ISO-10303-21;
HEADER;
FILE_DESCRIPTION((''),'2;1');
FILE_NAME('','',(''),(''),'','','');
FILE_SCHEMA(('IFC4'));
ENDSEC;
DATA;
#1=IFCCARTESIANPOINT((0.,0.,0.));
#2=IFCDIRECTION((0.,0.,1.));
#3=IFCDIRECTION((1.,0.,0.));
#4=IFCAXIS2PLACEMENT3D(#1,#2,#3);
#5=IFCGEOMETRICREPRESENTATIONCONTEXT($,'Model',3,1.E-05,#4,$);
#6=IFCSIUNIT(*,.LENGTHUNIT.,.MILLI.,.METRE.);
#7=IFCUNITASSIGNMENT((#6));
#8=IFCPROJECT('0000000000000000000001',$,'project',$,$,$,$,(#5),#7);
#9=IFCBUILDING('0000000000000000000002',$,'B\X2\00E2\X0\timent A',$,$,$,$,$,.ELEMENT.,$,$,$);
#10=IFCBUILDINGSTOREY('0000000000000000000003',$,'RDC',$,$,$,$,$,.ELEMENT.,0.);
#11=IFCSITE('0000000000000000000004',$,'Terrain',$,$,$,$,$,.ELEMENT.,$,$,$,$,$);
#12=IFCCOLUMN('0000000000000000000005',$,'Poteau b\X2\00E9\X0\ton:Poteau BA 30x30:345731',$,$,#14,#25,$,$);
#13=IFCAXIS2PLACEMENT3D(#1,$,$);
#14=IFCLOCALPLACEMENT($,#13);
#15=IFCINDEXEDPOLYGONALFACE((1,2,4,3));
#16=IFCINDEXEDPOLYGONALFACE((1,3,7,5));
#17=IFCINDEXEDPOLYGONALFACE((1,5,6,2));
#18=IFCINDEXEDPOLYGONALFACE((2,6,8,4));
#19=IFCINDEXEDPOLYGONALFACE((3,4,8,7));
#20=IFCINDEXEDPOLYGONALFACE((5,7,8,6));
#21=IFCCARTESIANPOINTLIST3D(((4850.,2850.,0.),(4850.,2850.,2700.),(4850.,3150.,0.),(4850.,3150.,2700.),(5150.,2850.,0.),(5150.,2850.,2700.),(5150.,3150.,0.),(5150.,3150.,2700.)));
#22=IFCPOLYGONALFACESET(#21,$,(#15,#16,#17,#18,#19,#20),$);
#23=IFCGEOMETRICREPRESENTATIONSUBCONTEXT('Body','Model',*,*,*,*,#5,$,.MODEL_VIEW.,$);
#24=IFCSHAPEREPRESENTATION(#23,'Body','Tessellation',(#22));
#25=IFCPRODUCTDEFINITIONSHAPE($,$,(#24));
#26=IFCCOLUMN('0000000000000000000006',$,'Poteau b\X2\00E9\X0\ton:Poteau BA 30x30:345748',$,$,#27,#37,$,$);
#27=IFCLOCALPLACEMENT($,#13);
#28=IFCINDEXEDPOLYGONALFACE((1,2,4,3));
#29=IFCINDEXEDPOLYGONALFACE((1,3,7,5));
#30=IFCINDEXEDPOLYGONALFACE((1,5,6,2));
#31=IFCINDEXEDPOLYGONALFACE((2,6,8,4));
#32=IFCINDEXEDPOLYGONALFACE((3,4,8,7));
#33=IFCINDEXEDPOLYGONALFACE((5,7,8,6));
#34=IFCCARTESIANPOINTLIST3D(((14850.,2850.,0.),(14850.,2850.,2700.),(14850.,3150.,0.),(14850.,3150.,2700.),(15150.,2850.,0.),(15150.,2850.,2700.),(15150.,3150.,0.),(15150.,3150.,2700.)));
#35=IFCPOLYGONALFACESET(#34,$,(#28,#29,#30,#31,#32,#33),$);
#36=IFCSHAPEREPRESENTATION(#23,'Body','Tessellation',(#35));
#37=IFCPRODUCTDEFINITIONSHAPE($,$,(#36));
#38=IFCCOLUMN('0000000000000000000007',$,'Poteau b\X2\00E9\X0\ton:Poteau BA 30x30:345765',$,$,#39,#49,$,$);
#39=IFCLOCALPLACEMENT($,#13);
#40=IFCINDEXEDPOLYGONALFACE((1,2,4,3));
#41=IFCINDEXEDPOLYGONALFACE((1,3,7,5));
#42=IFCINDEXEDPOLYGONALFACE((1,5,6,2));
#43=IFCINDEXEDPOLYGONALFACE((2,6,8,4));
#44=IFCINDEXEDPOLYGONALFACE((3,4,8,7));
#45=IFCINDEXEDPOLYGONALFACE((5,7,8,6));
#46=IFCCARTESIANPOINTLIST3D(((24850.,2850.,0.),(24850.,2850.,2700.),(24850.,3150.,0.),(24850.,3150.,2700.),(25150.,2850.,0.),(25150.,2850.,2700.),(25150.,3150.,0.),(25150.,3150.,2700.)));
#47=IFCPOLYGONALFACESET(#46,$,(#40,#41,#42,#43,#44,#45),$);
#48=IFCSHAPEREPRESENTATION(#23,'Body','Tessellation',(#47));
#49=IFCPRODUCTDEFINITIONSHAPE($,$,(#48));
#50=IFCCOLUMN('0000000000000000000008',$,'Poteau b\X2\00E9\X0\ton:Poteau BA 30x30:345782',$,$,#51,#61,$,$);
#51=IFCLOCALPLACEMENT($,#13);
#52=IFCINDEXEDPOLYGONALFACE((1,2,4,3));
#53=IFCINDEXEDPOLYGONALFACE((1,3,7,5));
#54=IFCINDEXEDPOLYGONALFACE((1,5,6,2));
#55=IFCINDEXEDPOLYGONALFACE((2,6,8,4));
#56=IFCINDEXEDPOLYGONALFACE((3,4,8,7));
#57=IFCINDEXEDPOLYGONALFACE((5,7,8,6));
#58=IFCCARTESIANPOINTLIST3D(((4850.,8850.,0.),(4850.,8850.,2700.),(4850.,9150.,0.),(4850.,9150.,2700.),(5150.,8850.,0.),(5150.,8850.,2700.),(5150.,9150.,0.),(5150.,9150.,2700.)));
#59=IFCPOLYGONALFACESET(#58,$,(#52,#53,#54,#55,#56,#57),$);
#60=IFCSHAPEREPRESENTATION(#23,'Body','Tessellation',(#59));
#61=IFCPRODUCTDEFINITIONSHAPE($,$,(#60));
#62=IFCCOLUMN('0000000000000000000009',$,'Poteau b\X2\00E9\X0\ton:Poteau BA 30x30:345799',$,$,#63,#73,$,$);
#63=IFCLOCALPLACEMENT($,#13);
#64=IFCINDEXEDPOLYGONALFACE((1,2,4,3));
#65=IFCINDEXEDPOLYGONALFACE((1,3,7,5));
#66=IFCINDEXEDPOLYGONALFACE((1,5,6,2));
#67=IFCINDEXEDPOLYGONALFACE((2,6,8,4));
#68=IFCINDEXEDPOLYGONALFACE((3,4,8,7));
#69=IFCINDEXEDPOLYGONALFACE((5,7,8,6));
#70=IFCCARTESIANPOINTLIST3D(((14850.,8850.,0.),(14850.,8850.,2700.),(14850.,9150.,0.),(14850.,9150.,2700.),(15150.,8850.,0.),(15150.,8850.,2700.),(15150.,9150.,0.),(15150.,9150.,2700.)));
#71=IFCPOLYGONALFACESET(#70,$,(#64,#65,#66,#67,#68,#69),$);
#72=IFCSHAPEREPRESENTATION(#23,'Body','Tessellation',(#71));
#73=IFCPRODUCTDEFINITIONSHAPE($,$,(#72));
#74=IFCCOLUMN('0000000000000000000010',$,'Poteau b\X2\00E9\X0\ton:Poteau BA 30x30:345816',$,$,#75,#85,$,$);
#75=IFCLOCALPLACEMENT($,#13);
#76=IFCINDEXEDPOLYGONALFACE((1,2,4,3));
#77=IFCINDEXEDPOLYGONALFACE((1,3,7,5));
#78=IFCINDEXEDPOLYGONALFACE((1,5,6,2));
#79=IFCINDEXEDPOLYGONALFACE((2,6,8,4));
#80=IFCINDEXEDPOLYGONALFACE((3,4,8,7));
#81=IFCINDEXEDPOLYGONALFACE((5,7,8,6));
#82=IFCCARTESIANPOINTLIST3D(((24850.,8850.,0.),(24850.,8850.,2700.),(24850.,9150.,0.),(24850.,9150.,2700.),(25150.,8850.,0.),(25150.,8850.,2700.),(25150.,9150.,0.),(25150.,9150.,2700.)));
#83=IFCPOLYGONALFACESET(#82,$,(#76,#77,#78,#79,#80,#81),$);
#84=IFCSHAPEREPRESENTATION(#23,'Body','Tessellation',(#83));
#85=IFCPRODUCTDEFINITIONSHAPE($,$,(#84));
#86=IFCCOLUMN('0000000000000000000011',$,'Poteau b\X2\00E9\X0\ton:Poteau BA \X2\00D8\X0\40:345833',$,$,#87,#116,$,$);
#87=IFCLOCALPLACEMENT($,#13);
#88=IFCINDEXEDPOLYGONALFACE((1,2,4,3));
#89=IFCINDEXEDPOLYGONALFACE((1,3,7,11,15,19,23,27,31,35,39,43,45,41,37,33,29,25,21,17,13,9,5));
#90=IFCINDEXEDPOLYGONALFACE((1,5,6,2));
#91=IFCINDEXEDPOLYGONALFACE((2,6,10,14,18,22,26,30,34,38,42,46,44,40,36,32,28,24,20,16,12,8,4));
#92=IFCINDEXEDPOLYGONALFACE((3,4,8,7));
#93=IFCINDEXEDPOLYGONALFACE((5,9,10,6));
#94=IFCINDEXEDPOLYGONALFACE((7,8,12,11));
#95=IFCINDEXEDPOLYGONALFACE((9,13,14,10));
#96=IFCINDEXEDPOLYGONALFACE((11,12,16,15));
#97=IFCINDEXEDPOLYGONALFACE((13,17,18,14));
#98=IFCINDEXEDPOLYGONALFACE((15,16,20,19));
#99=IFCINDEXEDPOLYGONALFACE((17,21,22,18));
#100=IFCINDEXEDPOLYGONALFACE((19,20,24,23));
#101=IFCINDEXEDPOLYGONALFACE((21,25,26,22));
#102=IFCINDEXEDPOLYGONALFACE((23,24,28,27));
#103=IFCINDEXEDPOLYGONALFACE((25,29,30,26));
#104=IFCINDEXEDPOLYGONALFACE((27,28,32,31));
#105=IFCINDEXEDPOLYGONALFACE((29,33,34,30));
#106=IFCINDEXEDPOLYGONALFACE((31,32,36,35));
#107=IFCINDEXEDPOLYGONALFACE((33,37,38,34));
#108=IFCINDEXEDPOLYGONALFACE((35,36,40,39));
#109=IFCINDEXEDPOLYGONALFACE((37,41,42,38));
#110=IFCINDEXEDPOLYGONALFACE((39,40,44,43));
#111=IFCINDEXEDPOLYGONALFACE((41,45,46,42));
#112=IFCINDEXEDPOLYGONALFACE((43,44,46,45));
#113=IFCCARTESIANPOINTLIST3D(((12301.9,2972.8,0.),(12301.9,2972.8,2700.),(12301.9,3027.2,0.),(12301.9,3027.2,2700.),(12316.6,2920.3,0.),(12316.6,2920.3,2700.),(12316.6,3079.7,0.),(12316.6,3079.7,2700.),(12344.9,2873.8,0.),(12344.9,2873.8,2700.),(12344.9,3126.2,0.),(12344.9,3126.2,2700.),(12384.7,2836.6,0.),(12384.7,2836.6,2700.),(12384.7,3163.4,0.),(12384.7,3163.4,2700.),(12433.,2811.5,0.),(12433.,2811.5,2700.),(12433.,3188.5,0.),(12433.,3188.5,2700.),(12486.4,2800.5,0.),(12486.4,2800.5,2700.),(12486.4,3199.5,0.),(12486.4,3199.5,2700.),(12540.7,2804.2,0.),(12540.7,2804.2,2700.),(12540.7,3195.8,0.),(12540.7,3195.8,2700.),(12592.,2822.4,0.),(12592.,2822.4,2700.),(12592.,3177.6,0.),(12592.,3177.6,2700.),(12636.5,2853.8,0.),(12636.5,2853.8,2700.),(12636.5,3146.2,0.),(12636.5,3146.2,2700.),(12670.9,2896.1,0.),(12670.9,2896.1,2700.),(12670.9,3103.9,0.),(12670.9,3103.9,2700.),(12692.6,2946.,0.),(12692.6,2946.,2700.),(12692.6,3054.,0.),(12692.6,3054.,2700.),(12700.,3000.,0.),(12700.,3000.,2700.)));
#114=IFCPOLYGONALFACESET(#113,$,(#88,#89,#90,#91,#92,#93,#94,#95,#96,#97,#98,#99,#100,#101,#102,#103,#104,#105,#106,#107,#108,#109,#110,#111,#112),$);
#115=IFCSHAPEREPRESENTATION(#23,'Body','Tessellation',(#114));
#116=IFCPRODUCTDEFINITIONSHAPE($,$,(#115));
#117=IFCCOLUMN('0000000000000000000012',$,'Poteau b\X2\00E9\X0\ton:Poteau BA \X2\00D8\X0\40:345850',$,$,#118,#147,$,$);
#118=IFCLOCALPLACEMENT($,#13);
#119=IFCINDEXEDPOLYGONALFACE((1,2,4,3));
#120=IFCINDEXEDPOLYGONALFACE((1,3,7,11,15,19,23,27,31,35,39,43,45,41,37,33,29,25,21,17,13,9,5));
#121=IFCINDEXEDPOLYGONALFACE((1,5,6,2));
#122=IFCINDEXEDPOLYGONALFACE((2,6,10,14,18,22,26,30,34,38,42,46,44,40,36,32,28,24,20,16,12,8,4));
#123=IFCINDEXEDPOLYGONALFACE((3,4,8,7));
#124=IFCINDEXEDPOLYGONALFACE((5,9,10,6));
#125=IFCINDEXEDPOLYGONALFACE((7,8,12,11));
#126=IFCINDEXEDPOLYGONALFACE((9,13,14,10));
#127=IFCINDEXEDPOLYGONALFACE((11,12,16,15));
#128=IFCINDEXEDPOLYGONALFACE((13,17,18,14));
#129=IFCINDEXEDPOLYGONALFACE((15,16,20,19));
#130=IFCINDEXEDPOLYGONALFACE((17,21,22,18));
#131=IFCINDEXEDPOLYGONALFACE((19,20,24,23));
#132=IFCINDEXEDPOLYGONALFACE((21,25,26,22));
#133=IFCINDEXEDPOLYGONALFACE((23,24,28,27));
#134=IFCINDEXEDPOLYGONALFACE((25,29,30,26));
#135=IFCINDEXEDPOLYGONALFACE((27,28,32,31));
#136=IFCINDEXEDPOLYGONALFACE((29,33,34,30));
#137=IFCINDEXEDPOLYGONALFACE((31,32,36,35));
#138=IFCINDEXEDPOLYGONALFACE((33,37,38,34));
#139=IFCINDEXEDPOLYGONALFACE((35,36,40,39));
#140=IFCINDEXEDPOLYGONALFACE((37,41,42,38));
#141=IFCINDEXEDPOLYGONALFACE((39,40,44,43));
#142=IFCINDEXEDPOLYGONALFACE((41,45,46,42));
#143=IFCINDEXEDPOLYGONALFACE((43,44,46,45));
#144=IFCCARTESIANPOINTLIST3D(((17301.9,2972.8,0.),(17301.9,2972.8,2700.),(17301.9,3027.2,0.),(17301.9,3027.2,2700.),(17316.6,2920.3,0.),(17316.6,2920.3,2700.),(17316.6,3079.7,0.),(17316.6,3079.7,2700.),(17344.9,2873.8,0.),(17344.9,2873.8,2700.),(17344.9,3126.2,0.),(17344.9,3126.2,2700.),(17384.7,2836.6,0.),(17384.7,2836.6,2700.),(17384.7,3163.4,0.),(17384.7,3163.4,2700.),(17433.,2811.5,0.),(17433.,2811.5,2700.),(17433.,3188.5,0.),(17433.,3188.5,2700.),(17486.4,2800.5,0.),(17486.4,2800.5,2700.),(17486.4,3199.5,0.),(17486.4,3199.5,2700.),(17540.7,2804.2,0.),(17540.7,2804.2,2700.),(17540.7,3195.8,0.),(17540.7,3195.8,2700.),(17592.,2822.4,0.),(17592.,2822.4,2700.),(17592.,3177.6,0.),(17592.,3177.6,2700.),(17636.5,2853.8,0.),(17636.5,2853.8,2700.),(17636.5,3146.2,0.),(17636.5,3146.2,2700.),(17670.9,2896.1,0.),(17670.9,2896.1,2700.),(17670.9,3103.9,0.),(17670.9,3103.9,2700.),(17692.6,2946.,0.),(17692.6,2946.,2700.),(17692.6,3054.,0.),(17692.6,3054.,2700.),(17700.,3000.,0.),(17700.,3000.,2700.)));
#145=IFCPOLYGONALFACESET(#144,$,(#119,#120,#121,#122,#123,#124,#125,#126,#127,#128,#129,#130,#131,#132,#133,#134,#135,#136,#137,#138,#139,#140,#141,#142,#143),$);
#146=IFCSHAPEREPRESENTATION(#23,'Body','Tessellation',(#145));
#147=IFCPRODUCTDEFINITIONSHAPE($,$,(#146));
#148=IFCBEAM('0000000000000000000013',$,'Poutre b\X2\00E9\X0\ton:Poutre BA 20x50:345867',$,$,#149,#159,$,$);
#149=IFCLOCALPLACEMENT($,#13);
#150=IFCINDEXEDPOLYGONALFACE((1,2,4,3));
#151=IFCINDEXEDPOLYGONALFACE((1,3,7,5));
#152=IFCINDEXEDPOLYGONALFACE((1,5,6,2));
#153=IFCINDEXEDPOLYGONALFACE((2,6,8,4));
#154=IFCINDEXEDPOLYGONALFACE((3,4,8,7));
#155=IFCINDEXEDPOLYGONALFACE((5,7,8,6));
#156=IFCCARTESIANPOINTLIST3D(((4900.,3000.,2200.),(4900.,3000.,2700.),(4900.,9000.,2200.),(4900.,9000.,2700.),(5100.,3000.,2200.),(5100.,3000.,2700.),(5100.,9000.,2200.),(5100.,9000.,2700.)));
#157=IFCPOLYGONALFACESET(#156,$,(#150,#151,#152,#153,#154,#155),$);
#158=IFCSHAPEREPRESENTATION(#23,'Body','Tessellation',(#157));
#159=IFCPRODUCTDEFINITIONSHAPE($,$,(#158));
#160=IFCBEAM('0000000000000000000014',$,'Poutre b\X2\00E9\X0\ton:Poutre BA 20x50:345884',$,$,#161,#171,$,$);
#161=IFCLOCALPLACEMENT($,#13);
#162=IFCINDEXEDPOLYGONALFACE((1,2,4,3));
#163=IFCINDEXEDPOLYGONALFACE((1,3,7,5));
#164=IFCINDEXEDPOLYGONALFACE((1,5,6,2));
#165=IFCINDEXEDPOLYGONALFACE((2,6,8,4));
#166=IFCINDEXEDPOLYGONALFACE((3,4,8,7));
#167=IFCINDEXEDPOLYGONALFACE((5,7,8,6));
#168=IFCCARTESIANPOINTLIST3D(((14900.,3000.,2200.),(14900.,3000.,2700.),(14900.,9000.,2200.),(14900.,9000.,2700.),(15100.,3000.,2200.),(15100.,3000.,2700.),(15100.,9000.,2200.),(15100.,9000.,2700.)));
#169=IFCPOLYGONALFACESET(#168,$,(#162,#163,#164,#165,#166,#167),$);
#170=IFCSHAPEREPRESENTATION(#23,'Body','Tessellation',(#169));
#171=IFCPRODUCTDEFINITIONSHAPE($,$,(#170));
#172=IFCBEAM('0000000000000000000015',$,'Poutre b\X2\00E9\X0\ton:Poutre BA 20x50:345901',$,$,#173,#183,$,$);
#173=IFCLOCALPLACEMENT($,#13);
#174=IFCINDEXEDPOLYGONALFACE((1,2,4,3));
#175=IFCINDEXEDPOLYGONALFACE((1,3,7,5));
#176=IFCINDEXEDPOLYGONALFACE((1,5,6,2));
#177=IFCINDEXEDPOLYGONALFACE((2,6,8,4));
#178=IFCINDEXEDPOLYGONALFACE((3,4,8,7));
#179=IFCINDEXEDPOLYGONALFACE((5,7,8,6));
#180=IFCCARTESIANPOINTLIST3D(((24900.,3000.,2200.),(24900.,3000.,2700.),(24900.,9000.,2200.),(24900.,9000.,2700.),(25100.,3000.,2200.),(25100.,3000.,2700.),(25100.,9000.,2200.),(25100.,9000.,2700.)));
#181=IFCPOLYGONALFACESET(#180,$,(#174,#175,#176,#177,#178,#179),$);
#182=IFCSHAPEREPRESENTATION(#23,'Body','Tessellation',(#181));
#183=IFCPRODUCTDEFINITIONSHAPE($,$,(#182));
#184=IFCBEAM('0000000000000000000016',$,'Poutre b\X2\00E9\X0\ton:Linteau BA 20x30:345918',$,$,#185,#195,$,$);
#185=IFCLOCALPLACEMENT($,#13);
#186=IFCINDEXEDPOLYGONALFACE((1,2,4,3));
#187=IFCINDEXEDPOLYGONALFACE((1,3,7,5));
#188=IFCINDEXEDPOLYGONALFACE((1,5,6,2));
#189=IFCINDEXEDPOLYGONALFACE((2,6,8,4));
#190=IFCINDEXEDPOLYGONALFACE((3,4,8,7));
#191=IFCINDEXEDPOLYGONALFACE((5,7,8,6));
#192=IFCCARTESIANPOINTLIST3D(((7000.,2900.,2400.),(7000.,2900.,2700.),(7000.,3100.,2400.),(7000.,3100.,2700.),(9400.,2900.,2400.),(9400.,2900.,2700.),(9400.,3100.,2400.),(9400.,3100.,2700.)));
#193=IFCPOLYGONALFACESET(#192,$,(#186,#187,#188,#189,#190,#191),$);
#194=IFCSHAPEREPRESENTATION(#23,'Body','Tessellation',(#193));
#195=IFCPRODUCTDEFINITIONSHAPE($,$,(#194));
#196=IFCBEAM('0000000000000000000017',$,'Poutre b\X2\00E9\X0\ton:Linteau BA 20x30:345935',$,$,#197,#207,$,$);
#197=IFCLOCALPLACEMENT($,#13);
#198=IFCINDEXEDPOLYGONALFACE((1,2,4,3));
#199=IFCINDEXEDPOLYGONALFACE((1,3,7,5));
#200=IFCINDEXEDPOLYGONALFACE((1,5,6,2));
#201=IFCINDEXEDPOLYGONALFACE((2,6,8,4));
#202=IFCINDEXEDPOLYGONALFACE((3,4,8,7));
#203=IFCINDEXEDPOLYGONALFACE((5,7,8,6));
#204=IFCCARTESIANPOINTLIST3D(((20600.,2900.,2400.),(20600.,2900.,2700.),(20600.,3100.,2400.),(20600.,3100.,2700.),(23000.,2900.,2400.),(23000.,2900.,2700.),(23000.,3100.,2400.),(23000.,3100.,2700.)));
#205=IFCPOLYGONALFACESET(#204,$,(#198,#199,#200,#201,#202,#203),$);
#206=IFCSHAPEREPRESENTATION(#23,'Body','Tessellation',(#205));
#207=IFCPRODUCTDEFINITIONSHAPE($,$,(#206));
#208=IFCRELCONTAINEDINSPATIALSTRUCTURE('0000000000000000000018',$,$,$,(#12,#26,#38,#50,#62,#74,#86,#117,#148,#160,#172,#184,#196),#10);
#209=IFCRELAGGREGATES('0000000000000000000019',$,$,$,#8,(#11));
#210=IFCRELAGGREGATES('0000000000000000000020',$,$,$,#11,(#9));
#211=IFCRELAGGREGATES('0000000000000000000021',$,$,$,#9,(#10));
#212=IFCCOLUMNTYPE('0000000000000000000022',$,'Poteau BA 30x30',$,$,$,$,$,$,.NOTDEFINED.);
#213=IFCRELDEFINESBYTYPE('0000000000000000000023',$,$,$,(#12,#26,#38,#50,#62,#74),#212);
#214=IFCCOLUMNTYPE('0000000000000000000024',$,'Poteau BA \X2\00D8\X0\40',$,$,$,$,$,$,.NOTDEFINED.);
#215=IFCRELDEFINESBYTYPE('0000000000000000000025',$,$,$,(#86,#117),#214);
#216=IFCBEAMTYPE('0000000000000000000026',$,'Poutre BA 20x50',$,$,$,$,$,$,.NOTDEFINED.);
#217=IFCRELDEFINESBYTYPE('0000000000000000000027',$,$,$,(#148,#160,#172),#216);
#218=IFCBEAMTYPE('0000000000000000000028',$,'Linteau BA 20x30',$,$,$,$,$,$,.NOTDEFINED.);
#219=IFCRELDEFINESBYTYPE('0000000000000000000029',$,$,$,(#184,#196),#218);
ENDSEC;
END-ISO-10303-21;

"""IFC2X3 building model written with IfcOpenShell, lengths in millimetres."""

from ifc_helpers import new_model, si_unit, frame, frame_2d, origin_with_axes, origin_2d, place, context, subcontext, project, spatial, rectangle, circle, extrude, type_object, element, save


model = new_model("IFC2X3")

# Units and contexts
model_context = context("Model", 3, precision=1e-05, world=origin_with_axes())
body_context = subcontext(model_context, "Body", "Model", "MODEL_VIEW")
ifc_project = project(units=[si_unit("LENGTHUNIT", "METRE", prefix="MILLI")], contexts=[model_context])

# Site, building, storey
site = spatial("IfcSite", under=ifc_project, Name="Terrain", CompositionType="ELEMENT")
building = spatial("IfcBuilding", under=site, Name="Bâtiment A", CompositionType="ELEMENT")
storey = spatial("IfcBuildingStorey", under=building, Name="RDC", CompositionType="ELEMENT", Elevation=0.0)

# Columns
column_type_1 = type_object("IfcColumnType", Name="Poteau BA 30x30", PredefinedType="NOTDEFINED")
column_1_placement = place(None, origin_with_axes())
element("IfcColumn", 1, at=column_1_placement, inside=storey, type_object=column_type_1, Name="Poteau béton:Poteau BA 30x30:345731", context=body_context, shape_type="SweptSolid", body=[
    extrude(rectangle(XDim=300.0, YDim=300.0, at=frame_2d((5000.0, 3000.0))), origin_with_axes(), (0.0, 0.0, 1.0), 2700.0),
])
column_2_placement = place(None, origin_with_axes())
element("IfcColumn", 2, at=column_2_placement, inside=storey, type_object=column_type_1, Name="Poteau béton:Poteau BA 30x30:345748", context=body_context, shape_type="SweptSolid", body=[
    extrude(rectangle(XDim=300.0, YDim=300.0, at=frame_2d((15000.0, 3000.0))), origin_with_axes(), (0.0, 0.0, 1.0), 2700.0),
])
column_3_placement = place(None, origin_with_axes())
element("IfcColumn", 3, at=column_3_placement, inside=storey, type_object=column_type_1, Name="Poteau béton:Poteau BA 30x30:345765", context=body_context, shape_type="SweptSolid", body=[
    extrude(rectangle(XDim=300.0, YDim=300.0, at=frame_2d((25000.0, 3000.0))), origin_with_axes(), (0.0, 0.0, 1.0), 2700.0),
])
column_4_placement = place(None, origin_with_axes())
element("IfcColumn", 4, at=column_4_placement, inside=storey, type_object=column_type_1, Name="Poteau béton:Poteau BA 30x30:345782", context=body_context, shape_type="SweptSolid", body=[
    extrude(rectangle(XDim=300.0, YDim=300.0, at=frame_2d((5000.0, 9000.0))), origin_with_axes(), (0.0, 0.0, 1.0), 2700.0),
])
column_5_placement = place(None, origin_with_axes())
element("IfcColumn", 5, at=column_5_placement, inside=storey, type_object=column_type_1, Name="Poteau béton:Poteau BA 30x30:345799", context=body_context, shape_type="SweptSolid", body=[
    extrude(rectangle(XDim=300.0, YDim=300.0, at=frame_2d((15000.0, 9000.0))), origin_with_axes(), (0.0, 0.0, 1.0), 2700.0),
])
column_6_placement = place(None, origin_with_axes())
element("IfcColumn", 6, at=column_6_placement, inside=storey, type_object=column_type_1, Name="Poteau béton:Poteau BA 30x30:345816", context=body_context, shape_type="SweptSolid", body=[
    extrude(rectangle(XDim=300.0, YDim=300.0, at=frame_2d((25000.0, 9000.0))), origin_with_axes(), (0.0, 0.0, 1.0), 2700.0),
])
column_type_2 = type_object("IfcColumnType", Name="Poteau BA Ø40", PredefinedType="NOTDEFINED")
column_7_placement = place(None, origin_with_axes())
element("IfcColumn", 7, at=column_7_placement, inside=storey, type_object=column_type_2, Name="Poteau béton:Poteau BA Ø40:345833", context=body_context, shape_type="SweptSolid", body=[
    extrude(circle(Radius=200.0, at=origin_2d()), frame((12500.0, 3000.0, 0.0), z_axis=(0.0, 0.0, 1.0), x_axis=(1.0, 0.0, 0.0)), (0.0, 0.0, 1.0), 2700.0),
])
column_8_placement = place(None, origin_with_axes())
element("IfcColumn", 8, at=column_8_placement, inside=storey, type_object=column_type_2, Name="Poteau béton:Poteau BA Ø40:345850", context=body_context, shape_type="SweptSolid", body=[
    extrude(circle(Radius=200.0, at=origin_2d()), frame((17500.0, 3000.0, 0.0), z_axis=(0.0, 0.0, 1.0), x_axis=(1.0, 0.0, 0.0)), (0.0, 0.0, 1.0), 2700.0),
])

# Beams
beam_type_1 = type_object("IfcBeamType", Name="Poutre BA 20x50", PredefinedType="NOTDEFINED")
beam_1_placement = place(None, origin_with_axes())
element("IfcBeam", 9, at=beam_1_placement, inside=storey, type_object=beam_type_1, Name="Poutre béton:Poutre BA 20x50:345867", context=body_context, shape_type="SweptSolid", body=[
    extrude(rectangle(XDim=200.0, YDim=6000.0, at=frame_2d((5000.0, 6000.0))), frame((0.0, 0.0, 2200.0), z_axis=(0.0, 0.0, 1.0), x_axis=(1.0, 0.0, 0.0)), (0.0, 0.0, 1.0), 500.0),
])
beam_2_placement = place(None, origin_with_axes())
element("IfcBeam", 10, at=beam_2_placement, inside=storey, type_object=beam_type_1, Name="Poutre béton:Poutre BA 20x50:345884", context=body_context, shape_type="SweptSolid", body=[
    extrude(rectangle(XDim=200.0, YDim=6000.0, at=frame_2d((15000.0, 6000.0))), frame((0.0, 0.0, 2200.0), z_axis=(0.0, 0.0, 1.0), x_axis=(1.0, 0.0, 0.0)), (0.0, 0.0, 1.0), 500.0),
])
beam_3_placement = place(None, origin_with_axes())
element("IfcBeam", 11, at=beam_3_placement, inside=storey, type_object=beam_type_1, Name="Poutre béton:Poutre BA 20x50:345901", context=body_context, shape_type="SweptSolid", body=[
    extrude(rectangle(XDim=200.0, YDim=6000.0, at=frame_2d((25000.0, 6000.0))), frame((0.0, 0.0, 2200.0), z_axis=(0.0, 0.0, 1.0), x_axis=(1.0, 0.0, 0.0)), (0.0, 0.0, 1.0), 500.0),
])
beam_type_2 = type_object("IfcBeamType", Name="Linteau BA 20x30", PredefinedType="NOTDEFINED")
beam_4_placement = place(None, origin_with_axes())
element("IfcBeam", 12, at=beam_4_placement, inside=storey, type_object=beam_type_2, Name="Poutre béton:Linteau BA 20x30:345918", context=body_context, shape_type="SweptSolid", body=[
    extrude(rectangle(XDim=2400.0, YDim=200.0, at=frame_2d((8200.0, 3000.0))), frame((0.0, 0.0, 2400.0), z_axis=(0.0, 0.0, 1.0), x_axis=(1.0, 0.0, 0.0)), (0.0, 0.0, 1.0), 300.0),
])
beam_5_placement = place(None, origin_with_axes())
element("IfcBeam", 13, at=beam_5_placement, inside=storey, type_object=beam_type_2, Name="Poutre béton:Linteau BA 20x30:345935", context=body_context, shape_type="SweptSolid", body=[
    extrude(rectangle(XDim=2400.0, YDim=200.0, at=frame_2d((21800.0, 3000.0))), frame((0.0, 0.0, 2400.0), z_axis=(0.0, 0.0, 1.0), x_axis=(1.0, 0.0, 0.0)), (0.0, 0.0, 1.0), 300.0),
])

save(model, "model.ifc")
